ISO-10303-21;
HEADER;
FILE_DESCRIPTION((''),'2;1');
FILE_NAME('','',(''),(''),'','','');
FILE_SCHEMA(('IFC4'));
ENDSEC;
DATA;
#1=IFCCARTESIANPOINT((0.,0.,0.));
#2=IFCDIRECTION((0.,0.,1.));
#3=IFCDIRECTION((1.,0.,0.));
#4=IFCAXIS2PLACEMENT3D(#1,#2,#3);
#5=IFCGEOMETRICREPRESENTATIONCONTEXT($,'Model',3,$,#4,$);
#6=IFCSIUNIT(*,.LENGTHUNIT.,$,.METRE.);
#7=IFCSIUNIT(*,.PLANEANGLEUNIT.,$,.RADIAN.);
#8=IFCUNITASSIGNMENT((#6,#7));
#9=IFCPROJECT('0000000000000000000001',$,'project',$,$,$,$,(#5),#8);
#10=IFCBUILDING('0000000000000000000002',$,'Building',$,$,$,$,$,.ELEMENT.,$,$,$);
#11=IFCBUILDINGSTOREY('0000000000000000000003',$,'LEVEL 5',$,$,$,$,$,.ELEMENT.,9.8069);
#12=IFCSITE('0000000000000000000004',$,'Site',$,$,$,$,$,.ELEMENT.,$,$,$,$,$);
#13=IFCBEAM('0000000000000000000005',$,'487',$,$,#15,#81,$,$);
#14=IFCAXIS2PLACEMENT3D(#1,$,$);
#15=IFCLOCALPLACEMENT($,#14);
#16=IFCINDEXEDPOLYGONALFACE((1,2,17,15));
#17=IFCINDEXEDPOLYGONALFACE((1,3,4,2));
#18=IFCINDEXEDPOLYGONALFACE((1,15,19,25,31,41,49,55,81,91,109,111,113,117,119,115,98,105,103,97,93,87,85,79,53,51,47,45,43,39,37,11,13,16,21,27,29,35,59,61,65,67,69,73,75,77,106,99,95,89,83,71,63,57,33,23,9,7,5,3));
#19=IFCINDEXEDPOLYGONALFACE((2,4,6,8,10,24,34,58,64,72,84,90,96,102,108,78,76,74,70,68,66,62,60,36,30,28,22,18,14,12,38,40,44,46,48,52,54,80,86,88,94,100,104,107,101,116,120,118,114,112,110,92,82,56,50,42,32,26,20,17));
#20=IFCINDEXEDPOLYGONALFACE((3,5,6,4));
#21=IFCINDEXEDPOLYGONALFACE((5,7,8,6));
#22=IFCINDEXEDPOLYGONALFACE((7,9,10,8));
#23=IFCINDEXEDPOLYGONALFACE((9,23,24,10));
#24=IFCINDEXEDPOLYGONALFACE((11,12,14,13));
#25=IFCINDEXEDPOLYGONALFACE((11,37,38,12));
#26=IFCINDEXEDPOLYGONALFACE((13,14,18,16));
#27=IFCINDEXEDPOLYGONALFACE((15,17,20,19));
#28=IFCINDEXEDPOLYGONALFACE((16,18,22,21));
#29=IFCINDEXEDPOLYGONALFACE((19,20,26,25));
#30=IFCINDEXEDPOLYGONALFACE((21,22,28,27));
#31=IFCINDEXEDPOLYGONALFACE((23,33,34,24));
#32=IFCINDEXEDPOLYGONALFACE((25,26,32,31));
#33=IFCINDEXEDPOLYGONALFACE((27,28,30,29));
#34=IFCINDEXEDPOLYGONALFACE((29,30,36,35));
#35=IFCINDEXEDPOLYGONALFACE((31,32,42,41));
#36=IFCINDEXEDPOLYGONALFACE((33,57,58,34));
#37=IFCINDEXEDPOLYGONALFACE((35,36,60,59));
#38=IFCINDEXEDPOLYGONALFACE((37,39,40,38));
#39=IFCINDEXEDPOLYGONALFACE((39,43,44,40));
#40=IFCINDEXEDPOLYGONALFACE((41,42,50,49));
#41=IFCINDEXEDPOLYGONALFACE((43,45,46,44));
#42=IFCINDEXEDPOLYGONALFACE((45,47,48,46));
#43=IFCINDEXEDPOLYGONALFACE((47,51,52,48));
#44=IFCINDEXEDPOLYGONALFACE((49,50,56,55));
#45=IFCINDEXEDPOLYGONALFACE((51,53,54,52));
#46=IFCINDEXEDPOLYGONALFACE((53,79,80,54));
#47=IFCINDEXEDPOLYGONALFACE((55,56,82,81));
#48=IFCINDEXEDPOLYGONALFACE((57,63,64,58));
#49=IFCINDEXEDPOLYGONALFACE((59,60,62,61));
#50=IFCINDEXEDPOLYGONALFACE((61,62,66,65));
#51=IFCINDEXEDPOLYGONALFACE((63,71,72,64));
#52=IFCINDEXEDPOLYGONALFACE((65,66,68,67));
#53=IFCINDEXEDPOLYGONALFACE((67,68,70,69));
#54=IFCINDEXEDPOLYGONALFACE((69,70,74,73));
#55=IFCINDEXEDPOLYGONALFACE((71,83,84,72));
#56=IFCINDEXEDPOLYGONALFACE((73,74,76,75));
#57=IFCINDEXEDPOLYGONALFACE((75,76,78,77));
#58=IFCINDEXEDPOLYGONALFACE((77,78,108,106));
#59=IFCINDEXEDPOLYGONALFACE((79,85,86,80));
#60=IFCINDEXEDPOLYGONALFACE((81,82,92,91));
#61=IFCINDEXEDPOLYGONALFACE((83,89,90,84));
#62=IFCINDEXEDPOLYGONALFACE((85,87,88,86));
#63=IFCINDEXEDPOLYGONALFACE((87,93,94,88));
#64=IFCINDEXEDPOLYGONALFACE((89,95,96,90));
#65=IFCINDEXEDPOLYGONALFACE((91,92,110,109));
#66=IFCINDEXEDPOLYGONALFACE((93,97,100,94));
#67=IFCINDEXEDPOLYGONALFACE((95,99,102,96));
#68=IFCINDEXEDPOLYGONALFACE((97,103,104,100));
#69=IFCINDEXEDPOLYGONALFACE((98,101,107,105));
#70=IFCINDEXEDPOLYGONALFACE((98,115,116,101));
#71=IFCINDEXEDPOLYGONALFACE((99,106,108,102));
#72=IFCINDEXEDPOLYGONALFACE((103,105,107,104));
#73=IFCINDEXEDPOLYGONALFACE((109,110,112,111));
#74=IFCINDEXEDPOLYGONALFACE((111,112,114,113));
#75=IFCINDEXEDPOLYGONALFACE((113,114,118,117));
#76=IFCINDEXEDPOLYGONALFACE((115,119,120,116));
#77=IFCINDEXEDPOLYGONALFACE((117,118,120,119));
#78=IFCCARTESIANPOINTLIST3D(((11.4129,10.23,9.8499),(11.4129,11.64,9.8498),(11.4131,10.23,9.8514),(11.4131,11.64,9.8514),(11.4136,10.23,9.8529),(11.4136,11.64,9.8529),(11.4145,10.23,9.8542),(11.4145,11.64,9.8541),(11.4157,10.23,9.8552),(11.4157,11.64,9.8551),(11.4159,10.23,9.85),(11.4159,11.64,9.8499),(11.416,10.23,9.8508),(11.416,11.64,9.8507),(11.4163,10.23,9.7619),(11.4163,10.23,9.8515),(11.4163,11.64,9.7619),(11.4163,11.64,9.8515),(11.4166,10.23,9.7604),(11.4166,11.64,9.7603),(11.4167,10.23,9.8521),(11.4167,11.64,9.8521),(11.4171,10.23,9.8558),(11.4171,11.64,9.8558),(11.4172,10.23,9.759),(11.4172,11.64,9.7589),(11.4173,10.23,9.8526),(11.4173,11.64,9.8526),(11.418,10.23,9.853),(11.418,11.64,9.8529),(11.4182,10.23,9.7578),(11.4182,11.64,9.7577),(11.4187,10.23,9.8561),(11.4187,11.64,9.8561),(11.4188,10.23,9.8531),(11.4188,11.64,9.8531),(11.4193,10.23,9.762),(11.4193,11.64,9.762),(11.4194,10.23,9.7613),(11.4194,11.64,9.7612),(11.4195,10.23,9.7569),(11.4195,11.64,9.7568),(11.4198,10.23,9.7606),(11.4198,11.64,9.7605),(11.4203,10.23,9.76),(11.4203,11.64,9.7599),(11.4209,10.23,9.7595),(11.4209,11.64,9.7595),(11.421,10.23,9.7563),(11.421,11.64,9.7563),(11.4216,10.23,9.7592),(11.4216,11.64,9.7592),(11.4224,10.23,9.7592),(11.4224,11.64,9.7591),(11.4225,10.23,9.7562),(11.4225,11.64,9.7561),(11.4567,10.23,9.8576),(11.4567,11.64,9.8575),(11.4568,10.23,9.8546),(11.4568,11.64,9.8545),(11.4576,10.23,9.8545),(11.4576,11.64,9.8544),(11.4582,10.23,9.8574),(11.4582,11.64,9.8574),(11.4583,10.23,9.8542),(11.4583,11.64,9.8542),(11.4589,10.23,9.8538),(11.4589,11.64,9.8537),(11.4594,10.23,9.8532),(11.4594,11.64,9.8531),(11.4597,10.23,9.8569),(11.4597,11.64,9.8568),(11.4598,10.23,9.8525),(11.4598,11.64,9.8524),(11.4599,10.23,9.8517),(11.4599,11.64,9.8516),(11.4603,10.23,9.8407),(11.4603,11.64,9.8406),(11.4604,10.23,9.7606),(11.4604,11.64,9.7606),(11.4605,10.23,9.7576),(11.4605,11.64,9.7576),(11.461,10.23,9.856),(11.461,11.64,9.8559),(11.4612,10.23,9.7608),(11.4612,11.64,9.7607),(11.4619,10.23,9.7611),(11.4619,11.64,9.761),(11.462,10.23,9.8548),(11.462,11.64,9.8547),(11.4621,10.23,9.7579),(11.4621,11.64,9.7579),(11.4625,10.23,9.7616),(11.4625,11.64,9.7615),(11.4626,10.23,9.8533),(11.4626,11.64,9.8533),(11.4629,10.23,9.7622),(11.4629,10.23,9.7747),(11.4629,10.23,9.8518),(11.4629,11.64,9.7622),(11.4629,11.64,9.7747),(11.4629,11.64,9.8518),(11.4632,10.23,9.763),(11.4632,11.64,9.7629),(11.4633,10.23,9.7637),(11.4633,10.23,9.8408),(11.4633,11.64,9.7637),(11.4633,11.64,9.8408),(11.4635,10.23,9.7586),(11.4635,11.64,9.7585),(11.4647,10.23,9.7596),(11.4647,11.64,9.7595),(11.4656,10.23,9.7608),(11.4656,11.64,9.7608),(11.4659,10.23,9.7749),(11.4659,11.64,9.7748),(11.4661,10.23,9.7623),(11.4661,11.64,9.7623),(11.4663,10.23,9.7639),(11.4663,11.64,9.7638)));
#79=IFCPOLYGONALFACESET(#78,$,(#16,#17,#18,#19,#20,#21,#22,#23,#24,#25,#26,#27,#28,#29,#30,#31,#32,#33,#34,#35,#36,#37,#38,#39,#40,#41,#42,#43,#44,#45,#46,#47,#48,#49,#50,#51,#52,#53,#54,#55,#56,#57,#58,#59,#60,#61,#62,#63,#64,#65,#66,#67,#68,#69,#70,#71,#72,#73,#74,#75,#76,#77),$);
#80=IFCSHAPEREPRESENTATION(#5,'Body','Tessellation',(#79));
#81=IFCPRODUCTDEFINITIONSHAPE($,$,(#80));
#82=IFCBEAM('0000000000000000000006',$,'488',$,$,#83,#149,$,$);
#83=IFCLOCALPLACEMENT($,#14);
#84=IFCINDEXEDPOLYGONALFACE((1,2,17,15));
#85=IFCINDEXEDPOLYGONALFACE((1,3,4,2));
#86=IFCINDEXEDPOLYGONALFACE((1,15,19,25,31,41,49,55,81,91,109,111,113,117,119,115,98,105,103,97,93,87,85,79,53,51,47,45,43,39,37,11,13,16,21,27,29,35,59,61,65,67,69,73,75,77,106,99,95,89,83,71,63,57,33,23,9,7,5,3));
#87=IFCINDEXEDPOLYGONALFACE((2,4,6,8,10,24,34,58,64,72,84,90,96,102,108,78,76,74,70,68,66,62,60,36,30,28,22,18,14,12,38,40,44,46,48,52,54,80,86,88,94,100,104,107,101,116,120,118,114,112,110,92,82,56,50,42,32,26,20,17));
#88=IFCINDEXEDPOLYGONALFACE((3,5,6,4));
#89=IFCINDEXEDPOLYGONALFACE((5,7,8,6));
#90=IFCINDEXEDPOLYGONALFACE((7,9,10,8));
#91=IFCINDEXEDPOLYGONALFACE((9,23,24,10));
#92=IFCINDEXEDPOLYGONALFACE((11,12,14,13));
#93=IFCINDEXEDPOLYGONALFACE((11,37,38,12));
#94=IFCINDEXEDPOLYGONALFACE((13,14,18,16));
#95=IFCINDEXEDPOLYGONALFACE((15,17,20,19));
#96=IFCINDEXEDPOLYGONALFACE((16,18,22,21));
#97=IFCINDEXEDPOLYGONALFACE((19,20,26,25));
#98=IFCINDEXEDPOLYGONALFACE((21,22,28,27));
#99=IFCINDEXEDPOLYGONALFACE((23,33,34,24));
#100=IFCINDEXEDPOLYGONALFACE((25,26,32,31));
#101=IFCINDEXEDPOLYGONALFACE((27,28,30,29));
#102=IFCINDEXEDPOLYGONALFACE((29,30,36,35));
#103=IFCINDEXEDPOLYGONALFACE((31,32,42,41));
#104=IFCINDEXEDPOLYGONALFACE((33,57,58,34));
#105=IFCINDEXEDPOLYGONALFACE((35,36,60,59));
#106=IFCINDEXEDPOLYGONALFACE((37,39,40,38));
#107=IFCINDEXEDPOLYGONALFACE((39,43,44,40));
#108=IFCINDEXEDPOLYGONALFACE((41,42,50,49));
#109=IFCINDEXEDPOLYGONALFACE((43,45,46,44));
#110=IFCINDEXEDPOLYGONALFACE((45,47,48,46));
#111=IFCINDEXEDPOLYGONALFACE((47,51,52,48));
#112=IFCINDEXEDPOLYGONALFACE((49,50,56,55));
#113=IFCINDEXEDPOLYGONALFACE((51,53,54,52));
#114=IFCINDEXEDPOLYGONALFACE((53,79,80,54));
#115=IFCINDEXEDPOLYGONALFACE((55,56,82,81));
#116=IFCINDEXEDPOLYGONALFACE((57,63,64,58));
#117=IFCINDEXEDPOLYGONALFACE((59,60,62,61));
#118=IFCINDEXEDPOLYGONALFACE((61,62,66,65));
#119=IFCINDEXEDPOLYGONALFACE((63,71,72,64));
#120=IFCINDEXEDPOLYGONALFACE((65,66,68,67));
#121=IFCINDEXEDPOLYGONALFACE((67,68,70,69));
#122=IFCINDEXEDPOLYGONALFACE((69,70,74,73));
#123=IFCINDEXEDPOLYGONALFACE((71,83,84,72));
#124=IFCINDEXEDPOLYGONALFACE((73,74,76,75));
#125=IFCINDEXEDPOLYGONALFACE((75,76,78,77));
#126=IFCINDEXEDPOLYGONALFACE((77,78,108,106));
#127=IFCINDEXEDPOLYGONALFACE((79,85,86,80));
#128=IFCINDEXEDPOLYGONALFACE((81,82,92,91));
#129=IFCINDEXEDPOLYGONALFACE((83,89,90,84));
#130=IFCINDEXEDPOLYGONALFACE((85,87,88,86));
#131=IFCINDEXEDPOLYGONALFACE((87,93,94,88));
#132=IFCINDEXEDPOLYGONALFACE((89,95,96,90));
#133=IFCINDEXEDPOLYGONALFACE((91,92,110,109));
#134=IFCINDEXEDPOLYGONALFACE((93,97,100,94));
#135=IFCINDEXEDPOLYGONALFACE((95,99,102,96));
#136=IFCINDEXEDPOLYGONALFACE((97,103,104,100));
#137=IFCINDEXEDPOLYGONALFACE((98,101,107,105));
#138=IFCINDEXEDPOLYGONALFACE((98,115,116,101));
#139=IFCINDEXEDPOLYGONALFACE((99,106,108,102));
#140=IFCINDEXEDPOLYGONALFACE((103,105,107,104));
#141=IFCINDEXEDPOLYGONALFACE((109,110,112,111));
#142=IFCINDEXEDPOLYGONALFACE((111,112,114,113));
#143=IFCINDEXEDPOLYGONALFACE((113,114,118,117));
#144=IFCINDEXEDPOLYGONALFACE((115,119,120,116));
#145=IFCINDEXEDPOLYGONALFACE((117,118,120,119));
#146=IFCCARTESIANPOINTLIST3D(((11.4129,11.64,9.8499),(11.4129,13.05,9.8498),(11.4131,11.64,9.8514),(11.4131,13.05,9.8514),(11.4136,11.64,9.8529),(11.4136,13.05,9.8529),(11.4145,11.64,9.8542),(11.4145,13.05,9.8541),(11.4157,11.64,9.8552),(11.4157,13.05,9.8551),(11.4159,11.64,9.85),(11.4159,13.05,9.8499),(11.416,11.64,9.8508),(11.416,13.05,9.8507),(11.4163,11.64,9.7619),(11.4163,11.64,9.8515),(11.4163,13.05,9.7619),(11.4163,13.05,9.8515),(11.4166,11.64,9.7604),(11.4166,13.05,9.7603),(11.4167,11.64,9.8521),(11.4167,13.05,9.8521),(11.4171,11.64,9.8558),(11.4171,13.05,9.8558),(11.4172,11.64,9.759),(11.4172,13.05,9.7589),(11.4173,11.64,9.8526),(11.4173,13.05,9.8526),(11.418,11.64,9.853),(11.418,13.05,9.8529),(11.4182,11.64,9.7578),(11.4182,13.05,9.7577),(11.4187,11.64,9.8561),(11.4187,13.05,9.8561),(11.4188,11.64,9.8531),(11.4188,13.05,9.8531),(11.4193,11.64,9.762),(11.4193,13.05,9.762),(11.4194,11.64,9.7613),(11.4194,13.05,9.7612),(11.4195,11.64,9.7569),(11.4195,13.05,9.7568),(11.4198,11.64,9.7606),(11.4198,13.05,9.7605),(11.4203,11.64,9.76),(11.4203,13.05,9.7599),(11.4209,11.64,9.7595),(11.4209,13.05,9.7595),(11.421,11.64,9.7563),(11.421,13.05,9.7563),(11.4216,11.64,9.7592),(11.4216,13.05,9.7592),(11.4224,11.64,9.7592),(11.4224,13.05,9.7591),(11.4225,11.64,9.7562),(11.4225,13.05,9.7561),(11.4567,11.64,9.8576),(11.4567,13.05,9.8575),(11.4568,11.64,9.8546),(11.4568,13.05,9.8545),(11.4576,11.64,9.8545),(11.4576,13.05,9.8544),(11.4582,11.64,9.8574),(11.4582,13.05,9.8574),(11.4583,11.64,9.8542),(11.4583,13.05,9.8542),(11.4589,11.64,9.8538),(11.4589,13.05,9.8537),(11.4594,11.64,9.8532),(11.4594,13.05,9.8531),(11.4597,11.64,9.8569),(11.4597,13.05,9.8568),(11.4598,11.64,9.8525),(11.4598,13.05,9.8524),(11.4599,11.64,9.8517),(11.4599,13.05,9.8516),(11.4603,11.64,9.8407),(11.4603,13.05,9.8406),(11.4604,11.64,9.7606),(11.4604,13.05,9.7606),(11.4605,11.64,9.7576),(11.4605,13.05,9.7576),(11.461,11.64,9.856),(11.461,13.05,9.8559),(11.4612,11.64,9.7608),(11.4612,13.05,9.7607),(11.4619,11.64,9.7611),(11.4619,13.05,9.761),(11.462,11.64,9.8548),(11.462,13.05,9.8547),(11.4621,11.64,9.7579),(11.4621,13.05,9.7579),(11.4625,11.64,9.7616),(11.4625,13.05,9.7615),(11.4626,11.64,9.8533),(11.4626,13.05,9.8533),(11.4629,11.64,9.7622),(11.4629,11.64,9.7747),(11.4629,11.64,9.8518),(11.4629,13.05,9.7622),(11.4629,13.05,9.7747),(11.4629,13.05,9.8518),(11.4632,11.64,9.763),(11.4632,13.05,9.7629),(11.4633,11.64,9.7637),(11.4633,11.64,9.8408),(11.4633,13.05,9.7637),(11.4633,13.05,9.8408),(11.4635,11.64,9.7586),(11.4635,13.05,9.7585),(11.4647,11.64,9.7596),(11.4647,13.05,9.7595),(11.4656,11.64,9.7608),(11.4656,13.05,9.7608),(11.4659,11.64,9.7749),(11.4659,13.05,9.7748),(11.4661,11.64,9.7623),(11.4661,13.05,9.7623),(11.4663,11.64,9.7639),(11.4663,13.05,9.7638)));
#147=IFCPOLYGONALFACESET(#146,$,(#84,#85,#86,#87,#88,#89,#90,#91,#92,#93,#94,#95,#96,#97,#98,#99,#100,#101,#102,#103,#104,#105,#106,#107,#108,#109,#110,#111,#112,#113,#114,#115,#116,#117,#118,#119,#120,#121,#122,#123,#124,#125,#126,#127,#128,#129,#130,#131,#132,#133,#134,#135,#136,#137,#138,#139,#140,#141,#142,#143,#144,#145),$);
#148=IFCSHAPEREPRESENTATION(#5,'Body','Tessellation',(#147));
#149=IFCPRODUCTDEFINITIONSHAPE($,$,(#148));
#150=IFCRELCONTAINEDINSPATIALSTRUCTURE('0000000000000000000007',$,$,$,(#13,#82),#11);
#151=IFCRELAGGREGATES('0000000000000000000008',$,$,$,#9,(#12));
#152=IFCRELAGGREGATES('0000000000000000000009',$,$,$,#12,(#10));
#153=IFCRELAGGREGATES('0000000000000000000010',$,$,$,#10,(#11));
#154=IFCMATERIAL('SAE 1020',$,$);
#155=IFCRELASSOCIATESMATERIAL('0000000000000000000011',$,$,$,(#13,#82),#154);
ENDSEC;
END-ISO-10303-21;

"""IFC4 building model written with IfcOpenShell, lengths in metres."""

from ifc_helpers import new_model, si_unit, frame, origin_with_axes, origin_2d_with_axis, place, context, project, spatial, c_section, extrude, material, material_profile, profile_set, profile_usage, element, save


model = new_model("IFC4")

# Units and contexts
model_context = context("Model", 3, world=origin_with_axes())
ifc_project = project(units=[si_unit("LENGTHUNIT", "METRE"), si_unit("PLANEANGLEUNIT", "RADIAN")], contexts=[model_context])

# Site, building, storey
site = spatial("IfcSite", under=ifc_project, Name="Site", CompositionType="ELEMENT")
building = spatial("IfcBuilding", under=site, Name="Building", CompositionType="ELEMENT")
storey = spatial("IfcBuildingStorey", under=building, Name="LEVEL 5", CompositionType="ELEMENT", Elevation=9.8069)

# Beams
ifc_material = material(Name="SAE 1020")
ifc_material_profile_1 = material_profile(ifc_material, c_section(Depth=0.1, Width=0.05, WallThickness=0.003, Girth=0.017, InternalFilletRadius=0.003, at=origin_2d_with_axis()))
ifc_profile_set_1 = profile_set([ifc_material_profile_1])
ifc_profile_usage_1 = profile_usage(ifc_profile_set_1, cardinal=10)
beam_1_placement = place(None, frame((11.4396, 10.23, 9.8069), z_axis=(0.0, 1.0, -0.00003), x_axis=(0.999256, 0.000001, 0.038562)))
element("IfcBeam", 1, at=beam_1_placement, inside=storey, material=ifc_profile_usage_1, Name="487", context=model_context, shape_type="SweptSolid", body=[
    extrude(c_section(Depth=0.1, Width=0.05, WallThickness=0.003, Girth=0.017, InternalFilletRadius=0.003, at=origin_2d_with_axis()), origin_with_axes(), (0.0, 0.0, 1.0), 1.41),
])
ifc_material_profile_2 = material_profile(ifc_material, c_section(Depth=0.1, Width=0.05, WallThickness=0.003, Girth=0.017, InternalFilletRadius=0.003, at=origin_2d_with_axis()))
ifc_profile_set_2 = profile_set([ifc_material_profile_2])
ifc_profile_usage_2 = profile_usage(ifc_profile_set_2, cardinal=10)
beam_2_placement = place(None, frame((11.4396, 11.64, 9.8069), z_axis=(0.0, 1.0, -0.00003), x_axis=(0.999256, 0.000001, 0.038562)))
element("IfcBeam", 2, at=beam_2_placement, inside=storey, material=ifc_profile_usage_2, Name="488", context=model_context, shape_type="SweptSolid", body=[
    extrude(c_section(Depth=0.1, Width=0.05, WallThickness=0.003, Girth=0.017, InternalFilletRadius=0.003, at=origin_2d_with_axis()), origin_with_axes(), (0.0, 0.0, 1.0), 1.41),
])

save(model, "model.ifc")
